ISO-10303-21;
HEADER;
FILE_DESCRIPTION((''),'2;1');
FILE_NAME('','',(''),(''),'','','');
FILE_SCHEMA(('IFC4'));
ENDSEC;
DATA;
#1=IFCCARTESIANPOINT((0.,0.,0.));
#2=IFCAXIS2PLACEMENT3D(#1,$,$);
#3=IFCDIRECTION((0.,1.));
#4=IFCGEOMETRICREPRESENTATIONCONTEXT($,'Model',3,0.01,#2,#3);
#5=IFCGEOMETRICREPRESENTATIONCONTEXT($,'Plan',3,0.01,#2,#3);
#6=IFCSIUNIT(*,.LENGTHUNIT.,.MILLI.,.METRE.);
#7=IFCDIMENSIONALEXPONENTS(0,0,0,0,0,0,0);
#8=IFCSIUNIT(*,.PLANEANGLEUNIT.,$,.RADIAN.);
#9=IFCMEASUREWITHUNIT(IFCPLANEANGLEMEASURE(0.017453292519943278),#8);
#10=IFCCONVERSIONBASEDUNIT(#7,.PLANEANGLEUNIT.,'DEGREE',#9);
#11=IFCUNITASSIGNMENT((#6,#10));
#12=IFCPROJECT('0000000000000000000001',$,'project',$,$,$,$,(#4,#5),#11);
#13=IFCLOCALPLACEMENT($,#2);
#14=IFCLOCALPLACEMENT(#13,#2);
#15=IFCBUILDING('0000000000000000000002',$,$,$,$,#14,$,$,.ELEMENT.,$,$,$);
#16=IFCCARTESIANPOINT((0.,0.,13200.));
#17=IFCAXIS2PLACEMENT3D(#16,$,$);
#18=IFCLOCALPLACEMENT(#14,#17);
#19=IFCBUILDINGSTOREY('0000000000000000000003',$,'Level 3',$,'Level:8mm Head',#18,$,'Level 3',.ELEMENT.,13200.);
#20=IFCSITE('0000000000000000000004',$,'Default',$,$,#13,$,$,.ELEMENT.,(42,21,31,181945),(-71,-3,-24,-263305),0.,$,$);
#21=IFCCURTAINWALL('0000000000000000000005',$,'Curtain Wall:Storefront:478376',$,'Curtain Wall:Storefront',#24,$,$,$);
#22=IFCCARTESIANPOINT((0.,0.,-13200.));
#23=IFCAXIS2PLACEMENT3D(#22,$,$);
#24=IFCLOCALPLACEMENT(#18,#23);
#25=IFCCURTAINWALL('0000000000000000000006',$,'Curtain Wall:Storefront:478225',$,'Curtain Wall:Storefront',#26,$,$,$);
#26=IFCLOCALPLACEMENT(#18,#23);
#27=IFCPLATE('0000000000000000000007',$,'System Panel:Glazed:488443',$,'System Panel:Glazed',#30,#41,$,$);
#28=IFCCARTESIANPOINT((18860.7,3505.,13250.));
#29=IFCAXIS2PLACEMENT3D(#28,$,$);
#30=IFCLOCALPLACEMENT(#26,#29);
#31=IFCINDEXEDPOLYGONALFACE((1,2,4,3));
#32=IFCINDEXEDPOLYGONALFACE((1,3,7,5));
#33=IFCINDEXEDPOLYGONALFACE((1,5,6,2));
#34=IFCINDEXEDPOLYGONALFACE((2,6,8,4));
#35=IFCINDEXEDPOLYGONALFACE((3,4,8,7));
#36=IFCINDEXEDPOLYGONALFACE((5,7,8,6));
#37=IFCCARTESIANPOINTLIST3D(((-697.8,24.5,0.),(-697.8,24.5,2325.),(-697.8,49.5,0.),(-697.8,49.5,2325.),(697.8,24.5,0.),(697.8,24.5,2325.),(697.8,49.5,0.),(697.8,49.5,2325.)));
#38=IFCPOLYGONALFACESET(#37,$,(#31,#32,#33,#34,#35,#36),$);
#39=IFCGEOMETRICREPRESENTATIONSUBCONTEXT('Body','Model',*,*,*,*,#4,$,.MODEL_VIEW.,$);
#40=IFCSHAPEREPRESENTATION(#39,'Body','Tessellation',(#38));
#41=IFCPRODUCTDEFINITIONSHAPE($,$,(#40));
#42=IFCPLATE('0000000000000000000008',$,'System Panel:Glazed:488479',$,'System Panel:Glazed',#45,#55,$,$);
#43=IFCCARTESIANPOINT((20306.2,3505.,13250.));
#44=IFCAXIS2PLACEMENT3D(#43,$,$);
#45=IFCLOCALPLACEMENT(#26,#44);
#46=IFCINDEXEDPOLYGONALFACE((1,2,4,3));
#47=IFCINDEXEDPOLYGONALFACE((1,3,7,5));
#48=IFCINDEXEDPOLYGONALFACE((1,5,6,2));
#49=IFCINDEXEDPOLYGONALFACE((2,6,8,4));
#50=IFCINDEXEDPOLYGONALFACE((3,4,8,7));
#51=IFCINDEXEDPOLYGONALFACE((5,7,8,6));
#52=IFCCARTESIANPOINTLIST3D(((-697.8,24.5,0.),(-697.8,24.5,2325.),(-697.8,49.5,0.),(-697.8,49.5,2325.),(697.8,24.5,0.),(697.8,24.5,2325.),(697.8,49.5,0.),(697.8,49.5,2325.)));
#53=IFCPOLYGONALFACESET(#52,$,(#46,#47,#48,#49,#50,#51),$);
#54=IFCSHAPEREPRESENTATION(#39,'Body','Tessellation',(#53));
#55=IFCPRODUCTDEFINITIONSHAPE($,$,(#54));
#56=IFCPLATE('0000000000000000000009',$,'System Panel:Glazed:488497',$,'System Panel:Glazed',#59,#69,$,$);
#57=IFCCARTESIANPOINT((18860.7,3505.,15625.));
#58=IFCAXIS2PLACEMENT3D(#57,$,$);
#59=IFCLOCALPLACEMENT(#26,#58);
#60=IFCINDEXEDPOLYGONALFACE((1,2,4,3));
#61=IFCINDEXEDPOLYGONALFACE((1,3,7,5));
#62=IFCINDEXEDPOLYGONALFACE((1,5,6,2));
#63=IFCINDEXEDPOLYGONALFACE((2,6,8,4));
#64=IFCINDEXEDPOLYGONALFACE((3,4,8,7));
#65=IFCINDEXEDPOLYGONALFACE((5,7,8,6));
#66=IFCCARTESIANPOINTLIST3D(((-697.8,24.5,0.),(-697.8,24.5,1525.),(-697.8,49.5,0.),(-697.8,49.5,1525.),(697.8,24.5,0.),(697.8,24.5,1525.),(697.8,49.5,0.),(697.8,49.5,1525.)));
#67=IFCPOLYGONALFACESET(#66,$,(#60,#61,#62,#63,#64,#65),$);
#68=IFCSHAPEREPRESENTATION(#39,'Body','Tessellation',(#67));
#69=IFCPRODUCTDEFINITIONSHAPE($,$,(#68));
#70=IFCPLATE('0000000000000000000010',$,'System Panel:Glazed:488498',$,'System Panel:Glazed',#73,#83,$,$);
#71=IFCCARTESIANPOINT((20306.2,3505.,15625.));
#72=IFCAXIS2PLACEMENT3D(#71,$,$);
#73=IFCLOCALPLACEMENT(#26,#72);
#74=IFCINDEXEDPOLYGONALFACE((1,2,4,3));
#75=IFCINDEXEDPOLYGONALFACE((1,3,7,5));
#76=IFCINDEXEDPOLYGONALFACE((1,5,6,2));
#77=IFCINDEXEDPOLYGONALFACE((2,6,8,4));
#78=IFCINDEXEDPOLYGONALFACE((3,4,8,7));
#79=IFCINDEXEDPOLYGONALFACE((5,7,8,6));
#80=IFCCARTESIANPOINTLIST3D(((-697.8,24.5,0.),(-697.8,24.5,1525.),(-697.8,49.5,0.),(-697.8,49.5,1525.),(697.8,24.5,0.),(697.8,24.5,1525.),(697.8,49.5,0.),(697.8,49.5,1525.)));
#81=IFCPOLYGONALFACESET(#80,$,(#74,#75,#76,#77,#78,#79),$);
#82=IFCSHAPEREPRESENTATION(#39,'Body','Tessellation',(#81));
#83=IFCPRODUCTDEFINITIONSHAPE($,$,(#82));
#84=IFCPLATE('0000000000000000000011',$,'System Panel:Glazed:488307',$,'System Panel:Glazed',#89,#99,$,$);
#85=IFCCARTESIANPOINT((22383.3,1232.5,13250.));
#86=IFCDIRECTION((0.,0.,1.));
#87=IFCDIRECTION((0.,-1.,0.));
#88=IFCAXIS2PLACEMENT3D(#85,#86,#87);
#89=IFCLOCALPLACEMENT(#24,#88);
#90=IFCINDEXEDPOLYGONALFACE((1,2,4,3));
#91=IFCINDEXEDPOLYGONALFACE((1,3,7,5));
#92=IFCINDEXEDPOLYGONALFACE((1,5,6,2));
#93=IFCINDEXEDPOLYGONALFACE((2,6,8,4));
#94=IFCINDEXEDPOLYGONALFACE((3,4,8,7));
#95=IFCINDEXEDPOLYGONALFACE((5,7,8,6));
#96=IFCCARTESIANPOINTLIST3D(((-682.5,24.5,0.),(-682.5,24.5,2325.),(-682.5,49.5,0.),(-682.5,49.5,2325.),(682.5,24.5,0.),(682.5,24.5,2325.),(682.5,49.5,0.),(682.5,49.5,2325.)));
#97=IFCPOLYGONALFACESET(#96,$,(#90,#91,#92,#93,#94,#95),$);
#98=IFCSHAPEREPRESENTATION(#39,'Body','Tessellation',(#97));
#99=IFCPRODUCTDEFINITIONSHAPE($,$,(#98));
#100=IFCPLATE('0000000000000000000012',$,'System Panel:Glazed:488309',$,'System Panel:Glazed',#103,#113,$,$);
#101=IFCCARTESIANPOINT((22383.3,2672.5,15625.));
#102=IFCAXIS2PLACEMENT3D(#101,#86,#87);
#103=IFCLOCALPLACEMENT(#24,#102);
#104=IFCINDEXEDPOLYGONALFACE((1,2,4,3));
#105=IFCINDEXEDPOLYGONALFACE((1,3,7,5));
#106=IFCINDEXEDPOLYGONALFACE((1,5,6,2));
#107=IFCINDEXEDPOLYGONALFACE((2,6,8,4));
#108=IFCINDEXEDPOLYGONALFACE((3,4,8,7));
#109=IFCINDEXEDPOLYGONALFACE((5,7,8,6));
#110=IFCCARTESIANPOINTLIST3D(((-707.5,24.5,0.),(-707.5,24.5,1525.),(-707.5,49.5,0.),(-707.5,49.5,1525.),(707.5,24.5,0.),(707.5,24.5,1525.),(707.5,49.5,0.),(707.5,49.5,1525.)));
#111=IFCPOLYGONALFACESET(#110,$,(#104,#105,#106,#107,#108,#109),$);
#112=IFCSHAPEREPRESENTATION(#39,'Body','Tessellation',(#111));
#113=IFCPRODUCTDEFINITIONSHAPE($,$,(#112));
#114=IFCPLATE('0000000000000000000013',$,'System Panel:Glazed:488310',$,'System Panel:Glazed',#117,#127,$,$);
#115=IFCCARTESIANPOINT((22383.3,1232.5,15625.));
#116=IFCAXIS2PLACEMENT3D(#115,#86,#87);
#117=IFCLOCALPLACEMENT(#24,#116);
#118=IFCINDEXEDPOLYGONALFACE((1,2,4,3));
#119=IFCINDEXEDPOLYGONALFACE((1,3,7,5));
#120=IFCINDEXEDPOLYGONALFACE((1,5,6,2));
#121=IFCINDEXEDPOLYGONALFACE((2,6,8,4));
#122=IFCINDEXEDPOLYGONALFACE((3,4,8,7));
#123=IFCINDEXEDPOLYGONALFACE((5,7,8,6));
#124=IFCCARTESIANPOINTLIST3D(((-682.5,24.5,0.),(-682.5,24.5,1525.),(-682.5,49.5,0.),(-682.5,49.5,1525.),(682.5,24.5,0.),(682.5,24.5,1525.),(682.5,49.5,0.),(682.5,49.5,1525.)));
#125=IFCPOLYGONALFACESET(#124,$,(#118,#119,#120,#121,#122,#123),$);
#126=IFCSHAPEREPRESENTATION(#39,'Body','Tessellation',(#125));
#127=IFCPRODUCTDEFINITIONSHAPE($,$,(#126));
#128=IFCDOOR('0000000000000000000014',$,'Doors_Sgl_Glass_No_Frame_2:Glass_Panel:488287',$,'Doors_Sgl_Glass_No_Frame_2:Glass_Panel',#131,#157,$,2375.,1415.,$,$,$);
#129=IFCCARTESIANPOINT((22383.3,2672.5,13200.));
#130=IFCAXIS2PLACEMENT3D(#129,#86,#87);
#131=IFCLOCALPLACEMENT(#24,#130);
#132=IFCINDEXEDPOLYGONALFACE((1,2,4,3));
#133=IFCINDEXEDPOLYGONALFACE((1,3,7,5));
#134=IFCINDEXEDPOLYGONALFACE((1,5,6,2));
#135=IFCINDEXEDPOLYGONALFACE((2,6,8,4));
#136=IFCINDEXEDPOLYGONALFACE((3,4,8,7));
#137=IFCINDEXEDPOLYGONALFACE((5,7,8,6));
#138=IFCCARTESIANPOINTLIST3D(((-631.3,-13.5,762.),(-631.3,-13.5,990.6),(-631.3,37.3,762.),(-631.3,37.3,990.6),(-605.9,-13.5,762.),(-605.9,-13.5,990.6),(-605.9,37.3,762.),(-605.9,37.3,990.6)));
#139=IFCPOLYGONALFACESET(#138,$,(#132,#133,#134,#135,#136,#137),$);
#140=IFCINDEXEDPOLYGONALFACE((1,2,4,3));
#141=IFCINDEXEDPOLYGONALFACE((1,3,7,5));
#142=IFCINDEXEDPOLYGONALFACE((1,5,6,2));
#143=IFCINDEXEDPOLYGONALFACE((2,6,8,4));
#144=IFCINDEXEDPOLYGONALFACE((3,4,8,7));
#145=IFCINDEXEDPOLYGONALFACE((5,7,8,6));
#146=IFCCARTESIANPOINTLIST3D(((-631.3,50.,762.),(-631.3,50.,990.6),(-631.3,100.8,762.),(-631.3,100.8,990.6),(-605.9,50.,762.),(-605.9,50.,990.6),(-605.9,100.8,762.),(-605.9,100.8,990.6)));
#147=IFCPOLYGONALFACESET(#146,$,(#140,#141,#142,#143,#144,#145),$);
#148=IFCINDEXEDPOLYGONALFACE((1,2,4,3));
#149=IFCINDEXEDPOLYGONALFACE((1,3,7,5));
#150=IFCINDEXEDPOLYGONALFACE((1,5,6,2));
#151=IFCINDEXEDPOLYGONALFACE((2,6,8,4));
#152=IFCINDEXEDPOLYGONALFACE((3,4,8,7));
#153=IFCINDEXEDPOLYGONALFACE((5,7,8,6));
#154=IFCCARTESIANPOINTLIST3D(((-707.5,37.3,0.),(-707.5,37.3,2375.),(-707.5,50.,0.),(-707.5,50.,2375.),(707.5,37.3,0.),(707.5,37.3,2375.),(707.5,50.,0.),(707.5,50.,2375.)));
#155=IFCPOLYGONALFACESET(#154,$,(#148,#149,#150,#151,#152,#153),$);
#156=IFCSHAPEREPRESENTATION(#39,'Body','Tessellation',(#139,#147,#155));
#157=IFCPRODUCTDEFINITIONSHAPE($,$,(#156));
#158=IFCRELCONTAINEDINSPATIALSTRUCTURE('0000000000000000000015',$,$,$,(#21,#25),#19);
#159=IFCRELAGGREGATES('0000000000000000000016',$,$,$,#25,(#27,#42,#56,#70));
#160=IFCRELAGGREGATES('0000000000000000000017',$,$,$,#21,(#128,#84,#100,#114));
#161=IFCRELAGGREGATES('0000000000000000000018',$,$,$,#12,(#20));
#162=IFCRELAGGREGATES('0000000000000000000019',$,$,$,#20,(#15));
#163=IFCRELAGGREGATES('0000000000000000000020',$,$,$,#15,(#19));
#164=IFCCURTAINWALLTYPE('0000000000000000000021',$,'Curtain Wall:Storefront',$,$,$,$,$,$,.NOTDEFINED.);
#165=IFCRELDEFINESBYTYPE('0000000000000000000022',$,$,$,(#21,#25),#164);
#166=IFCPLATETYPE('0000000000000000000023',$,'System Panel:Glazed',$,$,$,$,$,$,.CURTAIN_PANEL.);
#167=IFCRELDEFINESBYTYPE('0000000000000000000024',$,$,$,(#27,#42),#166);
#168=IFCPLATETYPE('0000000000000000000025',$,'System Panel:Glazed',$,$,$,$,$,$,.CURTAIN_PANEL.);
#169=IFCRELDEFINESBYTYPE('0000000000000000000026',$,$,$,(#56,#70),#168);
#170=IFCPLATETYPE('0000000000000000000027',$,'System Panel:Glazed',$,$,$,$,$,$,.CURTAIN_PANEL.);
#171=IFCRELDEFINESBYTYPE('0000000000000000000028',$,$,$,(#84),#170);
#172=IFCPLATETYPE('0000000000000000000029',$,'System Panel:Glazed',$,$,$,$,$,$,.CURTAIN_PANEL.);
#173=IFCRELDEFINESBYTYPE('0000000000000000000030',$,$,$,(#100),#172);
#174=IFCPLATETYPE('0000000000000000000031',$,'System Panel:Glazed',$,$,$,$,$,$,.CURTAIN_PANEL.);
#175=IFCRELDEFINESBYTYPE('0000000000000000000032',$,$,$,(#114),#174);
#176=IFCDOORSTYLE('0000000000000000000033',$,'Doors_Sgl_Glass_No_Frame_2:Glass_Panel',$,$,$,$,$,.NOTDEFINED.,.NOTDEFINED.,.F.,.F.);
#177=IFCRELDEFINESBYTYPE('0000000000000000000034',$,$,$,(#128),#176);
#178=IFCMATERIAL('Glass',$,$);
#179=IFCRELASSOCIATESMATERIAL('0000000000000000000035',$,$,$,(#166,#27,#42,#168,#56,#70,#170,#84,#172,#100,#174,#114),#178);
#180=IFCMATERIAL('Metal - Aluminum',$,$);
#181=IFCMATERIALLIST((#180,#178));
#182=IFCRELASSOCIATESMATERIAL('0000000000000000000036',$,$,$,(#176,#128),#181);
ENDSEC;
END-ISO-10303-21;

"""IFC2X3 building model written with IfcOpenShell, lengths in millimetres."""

from ifc_helpers import new_model, entity, si_unit, converted_unit, direction, frame, frame_2d, origin, origin_2d_with_axis, place, context, subcontext, project, spatial, rectangle, extrude, source, transform, mapped, material, material_list, type_object, type_shapes, element, aggregate, save


model = new_model("IFC2X3")

# Units and contexts
model_context = context("Model", 3, precision=0.01, world=origin(), true_north=direction((0.0, 1.0)))
plan_context = context("Plan", 3, precision=0.01, world=origin(), true_north=direction((0.0, 1.0)))
body_context = subcontext(model_context, "Body", "Model", "MODEL_VIEW")
ifc_project = project(units=[si_unit("LENGTHUNIT", "METRE", prefix="MILLI"), converted_unit("PLANEANGLEUNIT", "DEGREE", entity("IfcPlaneAngleMeasure", 0.017453292519943278), si_unit("PLANEANGLEUNIT", "RADIAN"), dimensions=[0, 0, 0, 0, 0, 0, 0])], contexts=[model_context, plan_context])

# Site, building, storey
site_placement = place(None, origin())
site = spatial("IfcSite", under=ifc_project, at=site_placement, Name="Default", CompositionType="ELEMENT", RefLatitude=(42, 21, 31, 181945), RefLongitude=(-71, -3, -24, -263305), RefElevation=0.0)
building_placement = place(site_placement, origin())
building = spatial("IfcBuilding", under=site, at=building_placement, CompositionType="ELEMENT")
storey_placement = place(building_placement, frame((0.0, 0.0, 13200.0)))
storey = spatial("IfcBuildingStorey", under=building, at=storey_placement, Name="Level 3", ObjectType="Level:8mm Head", LongName="Level 3", CompositionType="ELEMENT", Elevation=13200.0)

# Curtain walls
curtain_wall_type = type_object("IfcCurtainWallType", Name="Curtain Wall:Storefront", PredefinedType="NOTDEFINED")
curtain_wall_1_placement = place(storey_placement, frame((0.0, 0.0, -13200.0)))
curtain_wall_1 = element("IfcCurtainWall", 1, at=curtain_wall_1_placement, inside=storey, type_object=curtain_wall_type, Name="Curtain Wall:Storefront:478376", ObjectType="Curtain Wall:Storefront")
curtain_wall_2_placement = place(storey_placement, frame((0.0, 0.0, -13200.0)))
curtain_wall_2 = element("IfcCurtainWall", 2, at=curtain_wall_2_placement, inside=storey, type_object=curtain_wall_type, Name="Curtain Wall:Storefront:478225", ObjectType="Curtain Wall:Storefront")

# Plates
ifc_material_1 = material(Name="Glass")
plate_type_1 = type_object("IfcPlateType", Name="System Panel:Glazed", PredefinedType="CURTAIN_PANEL", material=ifc_material_1)
shared_shape_1 = source(origin(), body_context, "Body", "SweptSolid", [
    extrude(rectangle(XDim=25.0, YDim=1395.5, at=origin_2d_with_axis()), frame((0.0, 37.0, 0.0), z_axis=(0.0, 0.0, 1.0), x_axis=(0.0, 1.0, 0.0)), (0.0, 0.0, 1.0), 2325.0),
])
type_shapes(plate_type_1, [shared_shape_1])
plate_1_placement = place(curtain_wall_2_placement, frame((18860.7, 3505.0, 13250.0)))
plate_1 = element("IfcPlate", 3, at=plate_1_placement, type_object=plate_type_1, material=ifc_material_1, Name="System Panel:Glazed:488443", ObjectType="System Panel:Glazed", context=body_context, shape_type="MappedRepresentation", body=[
    mapped(shared_shape_1, transform((0.0, 0.0, 0.0), scale=1.0)),
])
plate_2_placement = place(curtain_wall_2_placement, frame((20306.2, 3505.0, 13250.0)))
plate_2 = element("IfcPlate", 4, at=plate_2_placement, type_object=plate_type_1, material=ifc_material_1, Name="System Panel:Glazed:488479", ObjectType="System Panel:Glazed", context=body_context, shape_type="MappedRepresentation", body=[
    mapped(shared_shape_1, transform((0.0, 0.0, 0.0), scale=1.0)),
])
plate_type_2 = type_object("IfcPlateType", Name="System Panel:Glazed", PredefinedType="CURTAIN_PANEL", material=ifc_material_1)
shared_shape_2 = source(origin(), body_context, "Body", "SweptSolid", [
    extrude(rectangle(XDim=25.0, YDim=1395.5, at=origin_2d_with_axis()), frame((0.0, 37.0, 0.0), z_axis=(0.0, 0.0, 1.0), x_axis=(0.0, 1.0, 0.0)), (0.0, 0.0, 1.0), 1525.0),
])
type_shapes(plate_type_2, [shared_shape_2])
plate_3_placement = place(curtain_wall_2_placement, frame((18860.7, 3505.0, 15625.0)))
plate_3 = element("IfcPlate", 5, at=plate_3_placement, type_object=plate_type_2, material=ifc_material_1, Name="System Panel:Glazed:488497", ObjectType="System Panel:Glazed", context=body_context, shape_type="MappedRepresentation", body=[
    mapped(shared_shape_2, transform((0.0, 0.0, 0.0), scale=1.0)),
])
plate_4_placement = place(curtain_wall_2_placement, frame((20306.2, 3505.0, 15625.0)))
plate_4 = element("IfcPlate", 6, at=plate_4_placement, type_object=plate_type_2, material=ifc_material_1, Name="System Panel:Glazed:488498", ObjectType="System Panel:Glazed", context=body_context, shape_type="MappedRepresentation", body=[
    mapped(shared_shape_2, transform((0.0, 0.0, 0.0), scale=1.0)),
])
aggregate(curtain_wall_2, [plate_1, plate_2, plate_3, plate_4])
plate_type_3 = type_object("IfcPlateType", Name="System Panel:Glazed", PredefinedType="CURTAIN_PANEL", material=ifc_material_1)
shared_shape_3 = source(origin(), body_context, "Body", "SweptSolid", [
    extrude(rectangle(XDim=25.0, YDim=1365.0, at=origin_2d_with_axis()), frame((0.0, 37.0, 0.0), z_axis=(0.0, 0.0, 1.0), x_axis=(0.0, 1.0, 0.0)), (0.0, 0.0, 1.0), 2325.0),
])
type_shapes(plate_type_3, [shared_shape_3])
plate_5_placement = place(curtain_wall_1_placement, frame((22383.3, 1232.5, 13250.0), z_axis=(0.0, 0.0, 1.0), x_axis=(0.0, -1.0, 0.0)))
plate_5 = element("IfcPlate", 7, at=plate_5_placement, type_object=plate_type_3, material=ifc_material_1, Name="System Panel:Glazed:488307", ObjectType="System Panel:Glazed", context=body_context, shape_type="MappedRepresentation", body=[
    mapped(shared_shape_3, transform((0.0, 0.0, 0.0), scale=1.0)),
])
plate_type_4 = type_object("IfcPlateType", Name="System Panel:Glazed", PredefinedType="CURTAIN_PANEL", material=ifc_material_1)
shared_shape_4 = source(origin(), body_context, "Body", "SweptSolid", [
    extrude(rectangle(XDim=25.0, YDim=1415.0, at=origin_2d_with_axis()), frame((0.0, 37.0, 0.0), z_axis=(0.0, 0.0, 1.0), x_axis=(0.0, 1.0, 0.0)), (0.0, 0.0, 1.0), 1525.0),
])
type_shapes(plate_type_4, [shared_shape_4])
plate_6_placement = place(curtain_wall_1_placement, frame((22383.3, 2672.5, 15625.0), z_axis=(0.0, 0.0, 1.0), x_axis=(0.0, -1.0, 0.0)))
plate_6 = element("IfcPlate", 8, at=plate_6_placement, type_object=plate_type_4, material=ifc_material_1, Name="System Panel:Glazed:488309", ObjectType="System Panel:Glazed", context=body_context, shape_type="MappedRepresentation", body=[
    mapped(shared_shape_4, transform((0.0, 0.0, 0.0), scale=1.0)),
])
plate_type_5 = type_object("IfcPlateType", Name="System Panel:Glazed", PredefinedType="CURTAIN_PANEL", material=ifc_material_1)
shared_shape_5 = source(origin(), body_context, "Body", "SweptSolid", [
    extrude(rectangle(XDim=25.0, YDim=1365.0, at=origin_2d_with_axis()), frame((0.0, 37.0, 0.0), z_axis=(0.0, 0.0, 1.0), x_axis=(0.0, 1.0, 0.0)), (0.0, 0.0, 1.0), 1525.0),
])
type_shapes(plate_type_5, [shared_shape_5])
plate_7_placement = place(curtain_wall_1_placement, frame((22383.3, 1232.5, 15625.0), z_axis=(0.0, 0.0, 1.0), x_axis=(0.0, -1.0, 0.0)))
plate_7 = element("IfcPlate", 9, at=plate_7_placement, type_object=plate_type_5, material=ifc_material_1, Name="System Panel:Glazed:488310", ObjectType="System Panel:Glazed", context=body_context, shape_type="MappedRepresentation", body=[
    mapped(shared_shape_5, transform((0.0, 0.0, 0.0), scale=1.0)),
])

# Door
ifc_material_2 = material(Name="Metal - Aluminum")
ifc_material_list = material_list([ifc_material_2, ifc_material_1])
door_style = type_object("IfcDoorStyle", Name="Doors_Sgl_Glass_No_Frame_2:Glass_Panel", ConstructionType="NOTDEFINED", OperationType="NOTDEFINED", ParameterTakesPrecedence=False, Sizeable=False, material=ifc_material_list)
shared_shape_6 = source(origin(), body_context, "Body", "SweptSolid", [
    extrude(rectangle(XDim=50.8, YDim=25.4, at=frame_2d((0.0, 0.0), x_axis=(1.0, 0.0))), frame((-618.6, 11.9, 762.0), z_axis=(0.0, 0.0, 1.0), x_axis=(0.0, 1.0, 0.0)), (0.0, 0.0, 1.0), 228.6),
    extrude(rectangle(XDim=50.8, YDim=25.4, at=frame_2d((0.0, 0.0), x_axis=(1.0, 0.0))), frame((-618.6, 75.4, 762.0), z_axis=(0.0, 0.0, 1.0), x_axis=(0.0, -1.0, 0.0)), (0.0, 0.0, 1.0), 228.6),
    extrude(rectangle(XDim=1415.0, YDim=12.7, at=frame_2d((0.0, 0.0), x_axis=(1.0, 0.0))), frame((0.0, 43.7, 0.0), z_axis=(0.0, 0.0, 1.0), x_axis=(-1.0, 0.0, 0.0)), (0.0, 0.0, 1.0), 2375.0),
])
type_shapes(door_style, [shared_shape_6])
door_placement = place(curtain_wall_1_placement, frame((22383.3, 2672.5, 13200.0), z_axis=(0.0, 0.0, 1.0), x_axis=(0.0, -1.0, 0.0)))
door = element("IfcDoor", 10, at=door_placement, type_object=door_style, material=ifc_material_list, Name="Doors_Sgl_Glass_No_Frame_2:Glass_Panel:488287", ObjectType="Doors_Sgl_Glass_No_Frame_2:Glass_Panel", OverallHeight=2375.0, OverallWidth=1415.0, context=body_context, shape_type="MappedRepresentation", body=[
    mapped(shared_shape_6, transform((0.0, 0.0, 0.0), scale=1.0)),
])
aggregate(curtain_wall_1, [door, plate_5, plate_6, plate_7])

save(model, "model.ifc")
